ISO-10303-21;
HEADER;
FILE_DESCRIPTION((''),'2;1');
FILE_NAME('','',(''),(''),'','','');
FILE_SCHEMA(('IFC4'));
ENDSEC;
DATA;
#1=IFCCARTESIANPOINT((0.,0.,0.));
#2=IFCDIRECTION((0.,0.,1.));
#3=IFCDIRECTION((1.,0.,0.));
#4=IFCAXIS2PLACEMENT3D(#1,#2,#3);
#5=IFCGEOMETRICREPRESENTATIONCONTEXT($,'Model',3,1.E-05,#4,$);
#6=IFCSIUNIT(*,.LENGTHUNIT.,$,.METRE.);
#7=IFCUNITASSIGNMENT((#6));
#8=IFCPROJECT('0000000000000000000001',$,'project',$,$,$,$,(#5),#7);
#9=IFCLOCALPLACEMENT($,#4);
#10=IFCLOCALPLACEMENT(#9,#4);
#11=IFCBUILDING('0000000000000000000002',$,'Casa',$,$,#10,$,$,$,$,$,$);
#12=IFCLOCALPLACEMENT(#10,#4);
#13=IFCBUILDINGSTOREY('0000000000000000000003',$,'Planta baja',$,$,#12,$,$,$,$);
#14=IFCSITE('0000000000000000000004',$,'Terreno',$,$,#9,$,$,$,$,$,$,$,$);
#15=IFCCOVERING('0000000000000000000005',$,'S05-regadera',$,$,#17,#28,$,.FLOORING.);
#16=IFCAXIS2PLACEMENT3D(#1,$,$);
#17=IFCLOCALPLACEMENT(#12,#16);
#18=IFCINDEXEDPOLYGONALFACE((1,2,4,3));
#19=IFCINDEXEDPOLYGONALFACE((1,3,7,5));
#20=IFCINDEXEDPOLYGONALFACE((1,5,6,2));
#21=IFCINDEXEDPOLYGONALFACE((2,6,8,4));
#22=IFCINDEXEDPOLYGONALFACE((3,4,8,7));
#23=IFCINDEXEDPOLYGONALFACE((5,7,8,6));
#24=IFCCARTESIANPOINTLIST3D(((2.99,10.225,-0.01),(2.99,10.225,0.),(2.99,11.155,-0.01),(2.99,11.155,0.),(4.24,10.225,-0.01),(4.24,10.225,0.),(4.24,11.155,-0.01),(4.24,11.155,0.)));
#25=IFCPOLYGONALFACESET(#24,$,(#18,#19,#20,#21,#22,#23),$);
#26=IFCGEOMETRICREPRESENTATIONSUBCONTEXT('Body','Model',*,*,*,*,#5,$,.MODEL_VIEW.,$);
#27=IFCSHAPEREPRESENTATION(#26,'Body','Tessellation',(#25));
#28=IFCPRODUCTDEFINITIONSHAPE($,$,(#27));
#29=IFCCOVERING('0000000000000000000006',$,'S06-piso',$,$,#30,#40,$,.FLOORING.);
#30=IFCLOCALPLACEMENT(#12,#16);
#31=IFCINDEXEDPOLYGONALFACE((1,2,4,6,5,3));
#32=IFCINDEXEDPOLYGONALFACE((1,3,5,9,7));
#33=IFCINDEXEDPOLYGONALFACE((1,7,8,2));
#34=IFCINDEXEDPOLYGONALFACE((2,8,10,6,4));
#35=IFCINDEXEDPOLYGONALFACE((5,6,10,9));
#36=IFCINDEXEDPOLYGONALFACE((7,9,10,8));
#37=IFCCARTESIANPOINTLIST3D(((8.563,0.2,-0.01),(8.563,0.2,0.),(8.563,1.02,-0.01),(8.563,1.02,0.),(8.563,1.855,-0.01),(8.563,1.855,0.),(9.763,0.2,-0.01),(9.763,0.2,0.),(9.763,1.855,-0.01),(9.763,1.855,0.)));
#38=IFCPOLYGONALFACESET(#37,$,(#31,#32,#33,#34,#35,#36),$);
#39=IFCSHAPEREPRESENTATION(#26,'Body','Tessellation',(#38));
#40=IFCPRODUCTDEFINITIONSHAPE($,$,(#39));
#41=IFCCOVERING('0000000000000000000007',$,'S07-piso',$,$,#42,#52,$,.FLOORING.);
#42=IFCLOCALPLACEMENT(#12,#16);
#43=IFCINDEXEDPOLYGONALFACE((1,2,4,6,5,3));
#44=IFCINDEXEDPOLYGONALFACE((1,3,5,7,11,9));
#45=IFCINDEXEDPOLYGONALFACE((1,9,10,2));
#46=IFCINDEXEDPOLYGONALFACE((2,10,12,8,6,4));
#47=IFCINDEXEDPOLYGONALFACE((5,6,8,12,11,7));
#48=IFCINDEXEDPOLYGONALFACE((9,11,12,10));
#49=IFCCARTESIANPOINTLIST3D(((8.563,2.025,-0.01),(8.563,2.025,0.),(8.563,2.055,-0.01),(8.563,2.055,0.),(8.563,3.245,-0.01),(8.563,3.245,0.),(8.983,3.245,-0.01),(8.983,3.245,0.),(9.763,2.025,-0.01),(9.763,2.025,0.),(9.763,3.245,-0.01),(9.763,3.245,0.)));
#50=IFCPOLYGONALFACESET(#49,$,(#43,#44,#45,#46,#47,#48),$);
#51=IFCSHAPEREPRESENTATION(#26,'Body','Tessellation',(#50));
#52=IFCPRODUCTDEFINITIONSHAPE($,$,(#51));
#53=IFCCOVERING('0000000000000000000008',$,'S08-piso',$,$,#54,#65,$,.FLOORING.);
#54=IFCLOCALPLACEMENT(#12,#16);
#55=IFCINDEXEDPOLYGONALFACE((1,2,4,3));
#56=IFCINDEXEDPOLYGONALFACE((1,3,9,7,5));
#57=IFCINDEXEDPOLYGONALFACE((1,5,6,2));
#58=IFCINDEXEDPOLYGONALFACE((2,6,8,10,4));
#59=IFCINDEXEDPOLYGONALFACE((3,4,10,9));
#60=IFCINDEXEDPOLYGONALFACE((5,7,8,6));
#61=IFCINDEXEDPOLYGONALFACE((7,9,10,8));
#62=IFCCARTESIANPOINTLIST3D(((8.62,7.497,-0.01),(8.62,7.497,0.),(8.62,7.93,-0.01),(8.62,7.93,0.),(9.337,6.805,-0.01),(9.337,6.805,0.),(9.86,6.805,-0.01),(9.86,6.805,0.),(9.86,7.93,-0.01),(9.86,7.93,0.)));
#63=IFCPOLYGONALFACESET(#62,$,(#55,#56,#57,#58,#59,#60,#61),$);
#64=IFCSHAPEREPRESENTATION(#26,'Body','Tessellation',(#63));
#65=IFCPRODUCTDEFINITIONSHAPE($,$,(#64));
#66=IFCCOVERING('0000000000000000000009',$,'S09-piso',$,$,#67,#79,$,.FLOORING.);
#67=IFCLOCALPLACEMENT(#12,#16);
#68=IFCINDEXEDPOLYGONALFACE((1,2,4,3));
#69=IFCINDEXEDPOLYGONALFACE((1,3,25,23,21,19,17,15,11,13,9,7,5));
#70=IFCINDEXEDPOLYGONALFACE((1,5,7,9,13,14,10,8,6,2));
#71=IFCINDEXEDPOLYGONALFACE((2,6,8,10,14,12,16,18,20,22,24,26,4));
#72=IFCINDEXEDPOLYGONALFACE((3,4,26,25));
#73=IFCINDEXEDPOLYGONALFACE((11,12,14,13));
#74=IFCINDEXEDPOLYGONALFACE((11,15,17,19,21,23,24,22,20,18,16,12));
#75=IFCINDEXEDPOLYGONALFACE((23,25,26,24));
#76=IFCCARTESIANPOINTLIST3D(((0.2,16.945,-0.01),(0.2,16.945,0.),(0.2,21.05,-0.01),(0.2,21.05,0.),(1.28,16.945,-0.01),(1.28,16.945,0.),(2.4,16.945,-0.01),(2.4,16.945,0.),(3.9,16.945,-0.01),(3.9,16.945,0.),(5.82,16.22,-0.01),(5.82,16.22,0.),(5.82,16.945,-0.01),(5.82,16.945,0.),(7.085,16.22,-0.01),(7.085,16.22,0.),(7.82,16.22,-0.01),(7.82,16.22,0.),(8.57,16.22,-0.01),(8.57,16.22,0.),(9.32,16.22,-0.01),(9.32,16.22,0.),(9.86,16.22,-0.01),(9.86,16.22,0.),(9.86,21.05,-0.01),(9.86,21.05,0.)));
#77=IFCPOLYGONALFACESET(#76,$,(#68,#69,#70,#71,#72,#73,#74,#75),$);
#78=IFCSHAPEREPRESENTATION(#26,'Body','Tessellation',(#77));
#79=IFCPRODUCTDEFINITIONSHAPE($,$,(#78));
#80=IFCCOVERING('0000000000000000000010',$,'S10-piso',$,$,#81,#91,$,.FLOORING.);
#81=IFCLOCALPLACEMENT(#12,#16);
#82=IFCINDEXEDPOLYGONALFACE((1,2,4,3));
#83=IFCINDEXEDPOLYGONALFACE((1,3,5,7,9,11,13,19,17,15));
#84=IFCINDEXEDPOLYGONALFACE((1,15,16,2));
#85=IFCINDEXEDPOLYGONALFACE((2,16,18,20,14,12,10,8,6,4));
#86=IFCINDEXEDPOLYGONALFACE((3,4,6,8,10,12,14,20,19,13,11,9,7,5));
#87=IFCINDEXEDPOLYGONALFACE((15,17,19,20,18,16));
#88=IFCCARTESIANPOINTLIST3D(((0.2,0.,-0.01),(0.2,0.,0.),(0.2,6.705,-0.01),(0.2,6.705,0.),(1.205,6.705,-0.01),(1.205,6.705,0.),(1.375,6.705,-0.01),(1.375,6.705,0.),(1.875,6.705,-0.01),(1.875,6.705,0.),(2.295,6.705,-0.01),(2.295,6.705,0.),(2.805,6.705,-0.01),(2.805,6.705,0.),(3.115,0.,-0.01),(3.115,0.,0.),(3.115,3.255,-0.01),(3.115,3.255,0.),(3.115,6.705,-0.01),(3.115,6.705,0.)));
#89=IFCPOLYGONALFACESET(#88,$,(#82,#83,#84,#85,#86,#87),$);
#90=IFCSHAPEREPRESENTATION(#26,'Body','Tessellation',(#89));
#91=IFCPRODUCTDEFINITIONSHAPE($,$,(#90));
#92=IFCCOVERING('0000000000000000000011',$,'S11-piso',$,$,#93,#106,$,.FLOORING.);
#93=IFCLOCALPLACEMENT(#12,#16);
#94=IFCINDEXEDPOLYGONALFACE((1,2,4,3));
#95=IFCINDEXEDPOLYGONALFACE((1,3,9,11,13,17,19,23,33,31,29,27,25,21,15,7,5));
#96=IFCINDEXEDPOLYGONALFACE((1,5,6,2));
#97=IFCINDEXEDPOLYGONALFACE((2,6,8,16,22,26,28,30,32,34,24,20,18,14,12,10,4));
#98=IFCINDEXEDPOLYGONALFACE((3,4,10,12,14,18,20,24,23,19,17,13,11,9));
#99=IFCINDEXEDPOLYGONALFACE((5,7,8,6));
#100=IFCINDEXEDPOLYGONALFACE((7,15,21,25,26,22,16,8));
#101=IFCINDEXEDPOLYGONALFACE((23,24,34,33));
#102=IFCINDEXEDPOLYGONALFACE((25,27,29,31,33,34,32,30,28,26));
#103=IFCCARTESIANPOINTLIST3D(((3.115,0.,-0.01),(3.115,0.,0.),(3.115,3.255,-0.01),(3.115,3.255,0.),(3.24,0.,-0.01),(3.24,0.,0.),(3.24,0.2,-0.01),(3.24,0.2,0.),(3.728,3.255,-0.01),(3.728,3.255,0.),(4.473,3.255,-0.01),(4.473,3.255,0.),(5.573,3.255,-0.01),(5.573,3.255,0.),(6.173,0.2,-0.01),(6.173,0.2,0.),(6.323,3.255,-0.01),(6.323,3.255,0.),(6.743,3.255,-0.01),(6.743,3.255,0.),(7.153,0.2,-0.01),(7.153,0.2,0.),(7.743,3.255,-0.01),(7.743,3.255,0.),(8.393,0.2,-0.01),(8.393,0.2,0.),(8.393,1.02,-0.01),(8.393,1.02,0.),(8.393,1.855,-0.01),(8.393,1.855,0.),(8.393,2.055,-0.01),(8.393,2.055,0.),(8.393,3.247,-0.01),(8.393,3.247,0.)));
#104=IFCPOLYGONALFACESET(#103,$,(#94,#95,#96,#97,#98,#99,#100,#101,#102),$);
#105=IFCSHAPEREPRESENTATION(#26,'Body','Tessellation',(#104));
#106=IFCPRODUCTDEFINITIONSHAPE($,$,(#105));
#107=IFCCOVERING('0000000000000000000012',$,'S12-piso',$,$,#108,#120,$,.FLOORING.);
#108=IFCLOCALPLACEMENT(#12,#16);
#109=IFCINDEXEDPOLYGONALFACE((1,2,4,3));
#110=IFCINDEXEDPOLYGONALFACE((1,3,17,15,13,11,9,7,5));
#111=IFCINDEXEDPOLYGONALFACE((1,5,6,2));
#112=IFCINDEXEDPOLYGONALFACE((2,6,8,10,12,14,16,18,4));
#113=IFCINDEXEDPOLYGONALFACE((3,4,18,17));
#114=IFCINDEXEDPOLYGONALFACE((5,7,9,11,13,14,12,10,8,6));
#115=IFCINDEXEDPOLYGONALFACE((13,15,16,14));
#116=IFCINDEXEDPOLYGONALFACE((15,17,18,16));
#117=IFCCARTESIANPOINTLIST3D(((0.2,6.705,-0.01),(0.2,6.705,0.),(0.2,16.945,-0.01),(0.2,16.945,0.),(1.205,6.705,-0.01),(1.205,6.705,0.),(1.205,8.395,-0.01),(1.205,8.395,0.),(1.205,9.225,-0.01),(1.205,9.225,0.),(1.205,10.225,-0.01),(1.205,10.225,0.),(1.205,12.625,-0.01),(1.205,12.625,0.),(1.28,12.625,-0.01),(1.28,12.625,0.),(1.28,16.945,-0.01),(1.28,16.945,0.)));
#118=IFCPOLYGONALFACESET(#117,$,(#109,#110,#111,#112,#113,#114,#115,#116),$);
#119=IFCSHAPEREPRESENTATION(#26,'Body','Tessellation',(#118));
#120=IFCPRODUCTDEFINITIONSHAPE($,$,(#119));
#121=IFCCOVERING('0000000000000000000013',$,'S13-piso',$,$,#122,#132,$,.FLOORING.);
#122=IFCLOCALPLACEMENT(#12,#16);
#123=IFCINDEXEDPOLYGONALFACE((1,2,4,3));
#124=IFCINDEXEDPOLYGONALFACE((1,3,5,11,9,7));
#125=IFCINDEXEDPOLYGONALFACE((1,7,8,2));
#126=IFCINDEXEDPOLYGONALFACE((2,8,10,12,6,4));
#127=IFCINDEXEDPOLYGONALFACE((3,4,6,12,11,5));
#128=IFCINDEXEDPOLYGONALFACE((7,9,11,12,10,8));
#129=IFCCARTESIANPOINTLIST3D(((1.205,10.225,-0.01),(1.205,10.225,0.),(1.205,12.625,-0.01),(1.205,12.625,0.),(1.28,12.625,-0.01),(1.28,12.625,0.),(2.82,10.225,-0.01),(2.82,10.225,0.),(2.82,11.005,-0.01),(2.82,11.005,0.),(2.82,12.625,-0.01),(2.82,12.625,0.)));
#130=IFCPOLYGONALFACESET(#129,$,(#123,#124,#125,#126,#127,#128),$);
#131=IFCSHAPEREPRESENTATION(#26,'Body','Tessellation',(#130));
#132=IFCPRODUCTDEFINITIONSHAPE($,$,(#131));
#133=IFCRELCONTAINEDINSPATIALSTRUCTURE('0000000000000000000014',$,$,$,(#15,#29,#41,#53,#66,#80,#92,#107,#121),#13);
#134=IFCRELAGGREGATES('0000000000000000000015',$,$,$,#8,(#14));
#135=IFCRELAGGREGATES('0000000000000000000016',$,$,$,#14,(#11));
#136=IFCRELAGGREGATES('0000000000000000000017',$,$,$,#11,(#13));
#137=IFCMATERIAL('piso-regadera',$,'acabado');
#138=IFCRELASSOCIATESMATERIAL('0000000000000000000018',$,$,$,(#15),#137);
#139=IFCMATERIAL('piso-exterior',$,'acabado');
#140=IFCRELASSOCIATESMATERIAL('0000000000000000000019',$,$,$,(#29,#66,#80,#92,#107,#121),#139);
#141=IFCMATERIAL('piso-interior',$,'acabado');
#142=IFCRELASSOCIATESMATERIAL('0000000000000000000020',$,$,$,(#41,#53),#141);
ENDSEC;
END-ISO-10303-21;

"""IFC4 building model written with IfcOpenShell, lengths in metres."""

from ifc_helpers import new_model, si_unit, frame, origin_with_axes, place, context, subcontext, project, spatial, line, indexed_curve, outline, extrude, material, element, save


model = new_model("IFC4")

# Units and contexts
model_context = context("Model", 3, precision=1e-05, world=origin_with_axes())
body_context = subcontext(model_context, "Body", "Model", "MODEL_VIEW")
ifc_project = project(units=[si_unit("LENGTHUNIT", "METRE")], contexts=[model_context])

# Site, building, storey
site_placement = place(None, origin_with_axes())
site = spatial("IfcSite", under=ifc_project, at=site_placement, Name="Terreno")
building_placement = place(site_placement, origin_with_axes())
building = spatial("IfcBuilding", under=site, at=building_placement, Name="Casa")
storey_placement = place(building_placement, origin_with_axes())
storey = spatial("IfcBuildingStorey", under=building, at=storey_placement, Name="Planta baja")

# Coverings
ifc_material_1 = material(Name="piso-interior", Category="acabado")
ifc_material_2 = material(Name="piso-regadera", Category="acabado")
covering_1_placement = place(storey_placement, origin_with_axes())
element("IfcCovering", 1, at=covering_1_placement, inside=storey, material=ifc_material_2, Name="S05-regadera", PredefinedType="FLOORING", context=body_context, shape_type="SweptSolid", body=[
    extrude(outline(indexed_curve([(4.24, 10.225), (2.99, 10.225), (2.99, 11.155), (4.24, 11.155)], segments=[line(1, 2, 3, 4, 1)])), frame((0.0, 0.0, -0.01), z_axis=(0.0, 0.0, 1.0), x_axis=(1.0, 0.0, 0.0)), (0.0, 0.0, 1.0), 0.01),
])
ifc_material_3 = material(Name="piso-exterior", Category="acabado")
covering_2_placement = place(storey_placement, origin_with_axes())
element("IfcCovering", 2, at=covering_2_placement, inside=storey, material=ifc_material_3, Name="S06-piso", PredefinedType="FLOORING", context=body_context, shape_type="SweptSolid", body=[
    extrude(outline(indexed_curve([(8.563, 1.02), (8.563, 1.855), (9.763, 1.855), (9.763, 0.2), (8.563, 0.2)], segments=[line(1, 2, 3, 4, 5, 1)])), frame((0.0, 0.0, -0.01), z_axis=(0.0, 0.0, 1.0), x_axis=(1.0, 0.0, 0.0)), (0.0, 0.0, 1.0), 0.01),
])
covering_3_placement = place(storey_placement, origin_with_axes())
element("IfcCovering", 3, at=covering_3_placement, inside=storey, material=ifc_material_1, Name="S07-piso", PredefinedType="FLOORING", context=body_context, shape_type="SweptSolid", body=[
    extrude(outline(indexed_curve([(8.983, 3.245), (9.763, 3.245), (9.763, 2.025), (8.563, 2.025), (8.563, 2.055), (8.563, 3.245)], segments=[line(1, 2, 3, 4, 5, 6, 1)])), frame((0.0, 0.0, -0.01), z_axis=(0.0, 0.0, 1.0), x_axis=(1.0, 0.0, 0.0)), (0.0, 0.0, 1.0), 0.01),
])
covering_4_placement = place(storey_placement, origin_with_axes())
element("IfcCovering", 4, at=covering_4_placement, inside=storey, material=ifc_material_1, Name="S08-piso", PredefinedType="FLOORING", context=body_context, shape_type="SweptSolid", body=[
    extrude(outline(indexed_curve([(9.86, 6.805), (9.337, 6.805), (8.62, 7.497), (8.62, 7.93), (9.86, 7.93)], segments=[line(1, 2, 3, 4, 5, 1)])), frame((0.0, 0.0, -0.01), z_axis=(0.0, 0.0, 1.0), x_axis=(1.0, 0.0, 0.0)), (0.0, 0.0, 1.0), 0.01),
])
covering_5_placement = place(storey_placement, origin_with_axes())
element("IfcCovering", 5, at=covering_5_placement, inside=storey, material=ifc_material_3, Name="S09-piso", PredefinedType="FLOORING", context=body_context, shape_type="SweptSolid", body=[
    extrude(outline(indexed_curve([(9.86, 16.22), (9.32, 16.22), (8.57, 16.22), (7.82, 16.22), (7.085, 16.22), (5.82, 16.22), (5.82, 16.945), (3.9, 16.945), (2.4, 16.945), (1.28, 16.945), (0.2, 16.945), (0.2, 21.05), (9.86, 21.05)], segments=[line(1, 2, 3, 4, 5, 6, 7, 8, 9, 10, 11, 12, 13, 1)])), frame((0.0, 0.0, -0.01), z_axis=(0.0, 0.0, 1.0), x_axis=(1.0, 0.0, 0.0)), (0.0, 0.0, 1.0), 0.01),
])
covering_6_placement = place(storey_placement, origin_with_axes())
element("IfcCovering", 6, at=covering_6_placement, inside=storey, material=ifc_material_3, Name="S10-piso", PredefinedType="FLOORING", context=body_context, shape_type="SweptSolid", body=[
    extrude(outline(indexed_curve([(1.875, 6.705), (2.295, 6.705), (2.805, 6.705), (3.115, 6.705), (3.115, 3.255), (3.115, 0.0), (0.2, 0.0), (0.2, 6.705), (1.205, 6.705), (1.375, 6.705)], segments=[line(1, 2, 3, 4, 5, 6, 7, 8, 9, 10, 1)])), frame((0.0, 0.0, -0.01), z_axis=(0.0, 0.0, 1.0), x_axis=(1.0, 0.0, 0.0)), (0.0, 0.0, 1.0), 0.01),
])
covering_7_placement = place(storey_placement, origin_with_axes())
element("IfcCovering", 7, at=covering_7_placement, inside=storey, material=ifc_material_3, Name="S11-piso", PredefinedType="FLOORING", context=body_context, shape_type="SweptSolid", body=[
    extrude(outline(indexed_curve([(6.323, 3.255), (6.743, 3.255), (7.743, 3.255), (8.393, 3.247), (8.393, 2.055), (8.393, 1.855), (8.393, 1.02), (8.393, 0.2), (7.153, 0.2), (6.173, 0.2), (3.24, 0.2), (3.24, 0.0), (3.115, 0.0), (3.115, 3.255), (3.728, 3.255), (4.473, 3.255), (5.573, 3.255)], segments=[line(1, 2, 3, 4, 5, 6, 7, 8, 9, 10, 11, 12, 13, 14, 15, 16, 17, 1)])), frame((0.0, 0.0, -0.01), z_axis=(0.0, 0.0, 1.0), x_axis=(1.0, 0.0, 0.0)), (0.0, 0.0, 1.0), 0.01),
])
covering_8_placement = place(storey_placement, origin_with_axes())
element("IfcCovering", 8, at=covering_8_placement, inside=storey, material=ifc_material_3, Name="S12-piso", PredefinedType="FLOORING", context=body_context, shape_type="SweptSolid", body=[
    extrude(outline(indexed_curve([(1.205, 9.225), (1.205, 8.395), (1.205, 6.705), (0.2, 6.705), (0.2, 16.945), (1.28, 16.945), (1.28, 12.625), (1.205, 12.625), (1.205, 10.225)], segments=[line(1, 2, 3, 4, 5, 6, 7, 8, 9, 1)])), frame((0.0, 0.0, -0.01), z_axis=(0.0, 0.0, 1.0), x_axis=(1.0, 0.0, 0.0)), (0.0, 0.0, 1.0), 0.01),
])
covering_9_placement = place(storey_placement, origin_with_axes())
element("IfcCovering", 9, at=covering_9_placement, inside=storey, material=ifc_material_3, Name="S13-piso", PredefinedType="FLOORING", context=body_context, shape_type="SweptSolid", body=[
    extrude(outline(indexed_curve([(2.82, 11.005), (2.82, 10.225), (1.205, 10.225), (1.205, 12.625), (1.28, 12.625), (2.82, 12.625)], segments=[line(1, 2, 3, 4, 5, 6, 1)])), frame((0.0, 0.0, -0.01), z_axis=(0.0, 0.0, 1.0), x_axis=(1.0, 0.0, 0.0)), (0.0, 0.0, 1.0), 0.01),
])

save(model, "model.ifc")
